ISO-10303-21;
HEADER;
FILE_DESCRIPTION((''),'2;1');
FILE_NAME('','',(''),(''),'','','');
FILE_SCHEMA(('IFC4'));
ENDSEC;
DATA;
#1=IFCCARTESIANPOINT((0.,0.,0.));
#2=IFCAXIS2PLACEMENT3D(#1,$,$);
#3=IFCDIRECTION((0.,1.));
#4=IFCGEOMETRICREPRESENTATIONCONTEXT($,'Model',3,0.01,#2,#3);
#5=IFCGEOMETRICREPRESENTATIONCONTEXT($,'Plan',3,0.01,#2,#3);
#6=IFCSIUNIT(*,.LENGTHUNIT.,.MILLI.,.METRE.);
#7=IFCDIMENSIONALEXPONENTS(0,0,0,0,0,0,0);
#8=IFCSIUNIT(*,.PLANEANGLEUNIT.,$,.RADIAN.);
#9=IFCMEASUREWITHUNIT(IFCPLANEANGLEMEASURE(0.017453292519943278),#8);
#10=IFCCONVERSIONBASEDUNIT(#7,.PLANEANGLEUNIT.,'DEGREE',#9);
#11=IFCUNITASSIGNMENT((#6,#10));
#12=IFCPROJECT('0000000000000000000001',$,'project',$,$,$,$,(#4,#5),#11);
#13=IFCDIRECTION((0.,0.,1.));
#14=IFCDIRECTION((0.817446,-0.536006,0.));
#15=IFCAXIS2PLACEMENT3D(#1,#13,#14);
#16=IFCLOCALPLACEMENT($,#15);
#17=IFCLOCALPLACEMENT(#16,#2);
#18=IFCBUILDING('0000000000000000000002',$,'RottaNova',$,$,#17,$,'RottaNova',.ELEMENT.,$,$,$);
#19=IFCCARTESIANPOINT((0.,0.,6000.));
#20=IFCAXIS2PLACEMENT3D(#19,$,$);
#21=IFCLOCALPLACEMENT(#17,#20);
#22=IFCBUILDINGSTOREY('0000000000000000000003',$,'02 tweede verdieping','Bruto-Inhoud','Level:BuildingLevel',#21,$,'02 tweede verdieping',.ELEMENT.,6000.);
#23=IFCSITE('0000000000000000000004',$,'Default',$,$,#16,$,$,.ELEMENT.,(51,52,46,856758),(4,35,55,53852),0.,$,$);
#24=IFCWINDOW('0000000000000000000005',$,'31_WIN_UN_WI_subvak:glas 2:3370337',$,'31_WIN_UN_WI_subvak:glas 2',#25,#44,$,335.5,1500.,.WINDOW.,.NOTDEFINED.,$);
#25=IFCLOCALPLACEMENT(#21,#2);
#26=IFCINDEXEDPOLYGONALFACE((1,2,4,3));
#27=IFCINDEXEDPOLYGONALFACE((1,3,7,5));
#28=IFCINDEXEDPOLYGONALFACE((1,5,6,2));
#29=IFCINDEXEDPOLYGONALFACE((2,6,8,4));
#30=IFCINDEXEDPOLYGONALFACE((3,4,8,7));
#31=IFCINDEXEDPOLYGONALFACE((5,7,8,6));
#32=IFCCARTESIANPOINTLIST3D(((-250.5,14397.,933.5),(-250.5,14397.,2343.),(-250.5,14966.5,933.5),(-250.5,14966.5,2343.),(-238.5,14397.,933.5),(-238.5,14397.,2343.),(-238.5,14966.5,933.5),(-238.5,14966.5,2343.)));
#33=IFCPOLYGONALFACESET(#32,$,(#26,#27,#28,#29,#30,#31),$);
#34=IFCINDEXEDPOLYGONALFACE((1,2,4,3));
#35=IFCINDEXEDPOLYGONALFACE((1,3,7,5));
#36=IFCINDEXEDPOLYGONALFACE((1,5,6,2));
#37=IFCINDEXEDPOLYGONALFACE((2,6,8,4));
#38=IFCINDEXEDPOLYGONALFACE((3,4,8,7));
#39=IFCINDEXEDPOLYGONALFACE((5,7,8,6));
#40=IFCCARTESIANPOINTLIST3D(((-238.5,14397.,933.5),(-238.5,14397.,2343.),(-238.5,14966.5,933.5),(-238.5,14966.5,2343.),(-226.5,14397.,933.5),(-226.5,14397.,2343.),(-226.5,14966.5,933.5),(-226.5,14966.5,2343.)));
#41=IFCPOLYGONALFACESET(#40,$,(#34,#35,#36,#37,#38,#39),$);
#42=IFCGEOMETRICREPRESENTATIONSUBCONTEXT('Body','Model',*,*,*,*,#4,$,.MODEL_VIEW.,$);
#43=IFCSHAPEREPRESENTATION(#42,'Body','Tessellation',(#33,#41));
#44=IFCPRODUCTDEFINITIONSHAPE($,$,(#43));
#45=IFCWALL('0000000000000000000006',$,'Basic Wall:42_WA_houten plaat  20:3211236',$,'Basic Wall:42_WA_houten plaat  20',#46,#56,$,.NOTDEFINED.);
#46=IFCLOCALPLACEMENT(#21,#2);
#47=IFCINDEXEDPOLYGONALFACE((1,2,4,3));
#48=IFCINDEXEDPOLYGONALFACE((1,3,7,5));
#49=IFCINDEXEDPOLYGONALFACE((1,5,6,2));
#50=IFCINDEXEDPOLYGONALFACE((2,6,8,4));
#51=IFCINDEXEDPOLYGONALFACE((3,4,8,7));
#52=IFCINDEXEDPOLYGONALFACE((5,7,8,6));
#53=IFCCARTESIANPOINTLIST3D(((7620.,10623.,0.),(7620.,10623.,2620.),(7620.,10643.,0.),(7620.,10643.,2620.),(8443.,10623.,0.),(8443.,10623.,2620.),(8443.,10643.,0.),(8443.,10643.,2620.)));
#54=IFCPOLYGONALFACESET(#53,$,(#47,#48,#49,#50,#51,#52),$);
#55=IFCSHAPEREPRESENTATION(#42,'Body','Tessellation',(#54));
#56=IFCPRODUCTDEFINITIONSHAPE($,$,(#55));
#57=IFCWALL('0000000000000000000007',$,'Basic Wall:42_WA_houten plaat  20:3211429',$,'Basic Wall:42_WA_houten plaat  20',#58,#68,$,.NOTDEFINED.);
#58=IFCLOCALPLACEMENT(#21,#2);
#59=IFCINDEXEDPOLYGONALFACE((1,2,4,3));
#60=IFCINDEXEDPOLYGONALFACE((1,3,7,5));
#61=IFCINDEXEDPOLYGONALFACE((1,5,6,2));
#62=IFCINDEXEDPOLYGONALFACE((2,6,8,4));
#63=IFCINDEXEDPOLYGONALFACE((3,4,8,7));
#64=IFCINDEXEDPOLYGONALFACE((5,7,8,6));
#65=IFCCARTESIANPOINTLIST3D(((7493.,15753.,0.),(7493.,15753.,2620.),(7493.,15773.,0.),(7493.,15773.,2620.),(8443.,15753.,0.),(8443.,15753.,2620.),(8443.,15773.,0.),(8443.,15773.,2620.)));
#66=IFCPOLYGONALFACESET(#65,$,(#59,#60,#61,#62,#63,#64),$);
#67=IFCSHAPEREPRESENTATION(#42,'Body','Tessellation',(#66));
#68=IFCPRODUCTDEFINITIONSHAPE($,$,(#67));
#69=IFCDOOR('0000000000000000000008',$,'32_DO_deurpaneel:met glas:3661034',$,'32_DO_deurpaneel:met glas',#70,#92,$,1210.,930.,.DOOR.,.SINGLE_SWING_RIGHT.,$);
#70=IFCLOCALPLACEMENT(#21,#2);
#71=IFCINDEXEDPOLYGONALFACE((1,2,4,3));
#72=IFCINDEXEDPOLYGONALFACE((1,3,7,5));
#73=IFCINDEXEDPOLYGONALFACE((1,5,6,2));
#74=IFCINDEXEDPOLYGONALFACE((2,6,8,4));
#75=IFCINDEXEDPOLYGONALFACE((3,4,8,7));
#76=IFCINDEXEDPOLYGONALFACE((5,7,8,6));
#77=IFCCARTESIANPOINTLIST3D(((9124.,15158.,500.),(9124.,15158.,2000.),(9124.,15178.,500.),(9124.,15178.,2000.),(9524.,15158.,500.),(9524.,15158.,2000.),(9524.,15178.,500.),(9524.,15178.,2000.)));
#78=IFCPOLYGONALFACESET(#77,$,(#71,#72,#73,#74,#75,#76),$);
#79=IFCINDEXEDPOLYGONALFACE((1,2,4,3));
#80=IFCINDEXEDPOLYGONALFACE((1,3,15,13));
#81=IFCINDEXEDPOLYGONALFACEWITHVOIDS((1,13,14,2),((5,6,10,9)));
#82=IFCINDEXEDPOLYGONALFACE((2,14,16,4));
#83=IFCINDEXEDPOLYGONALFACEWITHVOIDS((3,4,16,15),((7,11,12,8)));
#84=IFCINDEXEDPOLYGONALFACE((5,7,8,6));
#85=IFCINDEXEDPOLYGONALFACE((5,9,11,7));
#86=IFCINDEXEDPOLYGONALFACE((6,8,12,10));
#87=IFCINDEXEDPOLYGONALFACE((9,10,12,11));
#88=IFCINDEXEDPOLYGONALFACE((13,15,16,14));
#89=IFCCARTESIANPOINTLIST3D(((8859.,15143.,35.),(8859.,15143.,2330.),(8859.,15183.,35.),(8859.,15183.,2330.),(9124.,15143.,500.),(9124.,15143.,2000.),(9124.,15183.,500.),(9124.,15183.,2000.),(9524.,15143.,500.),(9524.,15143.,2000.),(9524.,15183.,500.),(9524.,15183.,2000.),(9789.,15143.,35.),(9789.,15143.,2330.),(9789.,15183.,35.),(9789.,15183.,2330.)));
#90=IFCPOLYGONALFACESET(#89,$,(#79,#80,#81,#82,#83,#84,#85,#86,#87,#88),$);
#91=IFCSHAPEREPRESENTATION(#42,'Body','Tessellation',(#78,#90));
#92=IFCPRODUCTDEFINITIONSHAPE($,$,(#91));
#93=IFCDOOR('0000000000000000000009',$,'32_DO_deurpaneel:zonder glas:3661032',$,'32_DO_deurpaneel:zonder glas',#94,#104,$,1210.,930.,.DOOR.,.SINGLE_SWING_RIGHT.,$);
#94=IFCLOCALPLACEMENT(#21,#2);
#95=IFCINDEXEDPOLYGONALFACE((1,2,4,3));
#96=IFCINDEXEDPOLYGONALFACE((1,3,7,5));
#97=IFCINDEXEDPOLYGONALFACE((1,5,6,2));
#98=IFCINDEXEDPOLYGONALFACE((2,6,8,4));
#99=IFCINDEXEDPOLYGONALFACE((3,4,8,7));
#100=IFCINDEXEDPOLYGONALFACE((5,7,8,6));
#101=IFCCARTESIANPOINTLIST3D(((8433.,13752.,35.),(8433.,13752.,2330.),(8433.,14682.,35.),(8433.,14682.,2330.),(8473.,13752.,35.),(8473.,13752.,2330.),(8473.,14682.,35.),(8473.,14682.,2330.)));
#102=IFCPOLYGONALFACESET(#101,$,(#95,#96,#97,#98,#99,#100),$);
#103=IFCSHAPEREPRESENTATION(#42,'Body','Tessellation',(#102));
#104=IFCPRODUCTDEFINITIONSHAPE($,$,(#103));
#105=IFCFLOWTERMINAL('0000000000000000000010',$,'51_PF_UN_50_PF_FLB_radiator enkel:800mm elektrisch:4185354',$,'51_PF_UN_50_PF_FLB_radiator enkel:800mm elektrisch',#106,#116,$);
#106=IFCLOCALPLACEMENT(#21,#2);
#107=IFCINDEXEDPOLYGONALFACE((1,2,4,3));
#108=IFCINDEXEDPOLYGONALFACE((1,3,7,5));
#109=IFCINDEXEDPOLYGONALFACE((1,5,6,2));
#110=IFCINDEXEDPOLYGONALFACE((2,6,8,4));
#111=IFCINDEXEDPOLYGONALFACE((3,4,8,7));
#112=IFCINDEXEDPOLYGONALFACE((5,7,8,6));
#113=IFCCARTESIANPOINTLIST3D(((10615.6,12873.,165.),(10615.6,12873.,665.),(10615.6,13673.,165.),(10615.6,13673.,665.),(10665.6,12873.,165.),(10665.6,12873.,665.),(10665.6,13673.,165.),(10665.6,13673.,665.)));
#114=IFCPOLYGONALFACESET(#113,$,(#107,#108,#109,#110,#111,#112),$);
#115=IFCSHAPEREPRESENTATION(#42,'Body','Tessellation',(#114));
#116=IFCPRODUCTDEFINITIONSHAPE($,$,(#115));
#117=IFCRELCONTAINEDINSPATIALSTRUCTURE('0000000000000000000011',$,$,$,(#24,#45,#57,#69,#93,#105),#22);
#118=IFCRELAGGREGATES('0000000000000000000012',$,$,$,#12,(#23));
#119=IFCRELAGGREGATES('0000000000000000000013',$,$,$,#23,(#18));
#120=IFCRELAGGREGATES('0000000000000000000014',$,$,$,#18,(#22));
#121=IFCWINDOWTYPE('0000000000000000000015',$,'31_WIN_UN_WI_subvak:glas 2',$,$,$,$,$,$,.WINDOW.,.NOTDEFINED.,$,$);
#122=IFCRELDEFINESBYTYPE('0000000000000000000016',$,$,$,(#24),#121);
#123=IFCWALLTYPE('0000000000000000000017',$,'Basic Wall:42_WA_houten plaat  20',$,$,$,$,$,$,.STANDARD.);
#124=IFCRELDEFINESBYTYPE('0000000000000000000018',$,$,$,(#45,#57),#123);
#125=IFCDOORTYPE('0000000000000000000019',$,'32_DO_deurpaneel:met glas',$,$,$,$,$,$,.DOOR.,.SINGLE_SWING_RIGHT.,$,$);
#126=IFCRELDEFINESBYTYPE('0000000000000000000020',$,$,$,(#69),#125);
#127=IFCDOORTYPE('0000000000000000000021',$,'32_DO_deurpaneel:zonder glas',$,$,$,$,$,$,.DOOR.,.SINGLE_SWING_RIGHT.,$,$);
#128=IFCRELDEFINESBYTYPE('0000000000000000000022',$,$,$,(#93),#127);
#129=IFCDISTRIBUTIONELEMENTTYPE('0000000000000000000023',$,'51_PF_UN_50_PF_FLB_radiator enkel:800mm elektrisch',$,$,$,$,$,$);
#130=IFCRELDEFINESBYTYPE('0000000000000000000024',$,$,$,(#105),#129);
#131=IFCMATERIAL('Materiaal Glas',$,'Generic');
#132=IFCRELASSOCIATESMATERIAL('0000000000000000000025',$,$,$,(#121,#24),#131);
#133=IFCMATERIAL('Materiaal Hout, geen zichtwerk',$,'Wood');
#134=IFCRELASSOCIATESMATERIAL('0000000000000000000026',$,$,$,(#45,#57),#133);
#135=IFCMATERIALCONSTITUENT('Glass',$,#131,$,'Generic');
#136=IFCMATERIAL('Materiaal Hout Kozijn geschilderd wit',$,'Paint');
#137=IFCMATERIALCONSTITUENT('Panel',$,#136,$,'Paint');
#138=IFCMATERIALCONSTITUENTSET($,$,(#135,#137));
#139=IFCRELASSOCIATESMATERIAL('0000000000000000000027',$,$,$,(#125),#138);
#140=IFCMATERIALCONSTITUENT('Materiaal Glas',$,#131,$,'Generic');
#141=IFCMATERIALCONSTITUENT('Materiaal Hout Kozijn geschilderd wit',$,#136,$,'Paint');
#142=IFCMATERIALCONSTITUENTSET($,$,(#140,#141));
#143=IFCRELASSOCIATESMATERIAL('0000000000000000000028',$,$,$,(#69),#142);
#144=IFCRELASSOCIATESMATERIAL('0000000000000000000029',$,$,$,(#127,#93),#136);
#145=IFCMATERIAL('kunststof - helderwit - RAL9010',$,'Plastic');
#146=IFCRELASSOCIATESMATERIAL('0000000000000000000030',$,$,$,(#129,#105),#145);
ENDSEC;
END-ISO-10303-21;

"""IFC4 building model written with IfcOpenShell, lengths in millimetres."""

from ifc_helpers import new_model, entity, si_unit, converted_unit, direction, frame, origin, place, context, subcontext, project, spatial, indexed_curve, outline, extrude, source, transform, mapped, material, constituent, constituent_set, type_object, type_shapes, element, save


model = new_model("IFC4")

# Units and contexts
model_context = context("Model", 3, precision=0.01, world=origin(), true_north=direction((0.0, 1.0)))
plan_context = context("Plan", 3, precision=0.01, world=origin(), true_north=direction((0.0, 1.0)))
body_context = subcontext(model_context, "Body", "Model", "MODEL_VIEW")
ifc_project = project(units=[si_unit("LENGTHUNIT", "METRE", prefix="MILLI"), converted_unit("PLANEANGLEUNIT", "DEGREE", entity("IfcPlaneAngleMeasure", 0.017453292519943278), si_unit("PLANEANGLEUNIT", "RADIAN"), dimensions=[0, 0, 0, 0, 0, 0, 0])], contexts=[model_context, plan_context])

# Site, building, storey
site_placement = place(None, frame((0.0, 0.0, 0.0), z_axis=(0.0, 0.0, 1.0), x_axis=(0.817446, -0.536006, 0.0)))
site = spatial("IfcSite", under=ifc_project, at=site_placement, Name="Default", CompositionType="ELEMENT", RefLatitude=(51, 52, 46, 856758), RefLongitude=(4, 35, 55, 53852), RefElevation=0.0)
building_placement = place(site_placement, origin())
building = spatial("IfcBuilding", under=site, at=building_placement, Name="RottaNova", LongName="RottaNova", CompositionType="ELEMENT")
storey_placement = place(building_placement, frame((0.0, 0.0, 6000.0)))
storey = spatial("IfcBuildingStorey", under=building, at=storey_placement, Name="02 tweede verdieping", Description="Bruto-Inhoud", ObjectType="Level:BuildingLevel", LongName="02 tweede verdieping", CompositionType="ELEMENT", Elevation=6000.0)

# Shared definitions
ifc_material_1 = material(Name="Materiaal Glas", Category="Generic")

# Window
window_type = type_object("IfcWindowType", Name="31_WIN_UN_WI_subvak:glas 2", PartitioningType="NOTDEFINED", PredefinedType="WINDOW", material=ifc_material_1)
shared_shape_1 = source(origin(), body_context, "Body", "SweptSolid", [
    extrude(outline(indexed_curve([(-284.7, -6.0), (284.7, -6.0), (284.7, 6.0), (-284.7, 6.0), (-284.7, -6.0)], self_intersect=False)), frame((0.0, -6.0, 0.0)), (0.0, 0.0, 1.0), 1409.5),
    extrude(outline(indexed_curve([(-284.8, -6.0), (284.8, -6.0), (284.8, 6.0), (-284.8, 6.0), (-284.8, -6.0)], self_intersect=False)), frame((0.0, 6.0, 0.0)), (0.0, 0.0, 1.0), 1409.5),
])
type_shapes(window_type, [shared_shape_1])
window_1_placement = place(storey_placement, frame((-238.5, 14681.8, 933.5), z_axis=(0.0, 0.0, 1.0), x_axis=(0.0, -1.0, 0.0)))
element("IfcWindow", 1, at=window_1_placement, inside=storey, type_object=window_type, material=ifc_material_1, Name="31_WIN_UN_WI_subvak:glas 2:3370337", ObjectType="31_WIN_UN_WI_subvak:glas 2", OverallHeight=335.5, OverallWidth=1500.0, PartitioningType="NOTDEFINED", PredefinedType="WINDOW", context=body_context, shape_type="MappedRepresentation", body=[
    mapped(shared_shape_1, transform((0.0, 0.0, 0.0), scale=1.0)),
])

# Walls
ifc_material_2 = material(Name="Materiaal Hout, geen zichtwerk", Category="Wood")
wall_type_1 = type_object("IfcWallType", Name="Basic Wall:42_WA_houten plaat  20", PredefinedType="STANDARD")
wall_1_placement = place(storey_placement, frame((7620.0, 10633.0, 0.0)))
element("IfcWall", 2, at=wall_1_placement, inside=storey, type_object=wall_type_1, material=ifc_material_2, Name="Basic Wall:42_WA_houten plaat  20:3211236", ObjectType="Basic Wall:42_WA_houten plaat  20", PredefinedType="NOTDEFINED", context=body_context, shape_type="SweptSolid", body=[
    extrude(outline(indexed_curve([(823.0, 10.0), (0.0, 10.0), (0.0, -10.0), (823.0, -10.0), (823.0, 10.0)], self_intersect=False)), origin(), (0.0, 0.0, 1.0), 2620.0),
])
wall_2_placement = place(storey_placement, frame((7493.0, 15763.0, 0.0)))
element("IfcWall", 3, at=wall_2_placement, inside=storey, type_object=wall_type_1, material=ifc_material_2, Name="Basic Wall:42_WA_houten plaat  20:3211429", ObjectType="Basic Wall:42_WA_houten plaat  20", PredefinedType="NOTDEFINED", context=body_context, shape_type="SweptSolid", body=[
    extrude(outline(indexed_curve([(950.0, 10.0), (0.0, 10.0), (0.0, -10.0), (950.0, -10.0), (950.0, 10.0)], self_intersect=False)), origin(), (0.0, 0.0, 1.0), 2620.0),
])

# Doors
ifc_constituent_1 = constituent(ifc_material_1, Name="Materiaal Glas", Category="Generic")
ifc_material_3 = material(Name="Materiaal Hout Kozijn geschilderd wit", Category="Paint")
ifc_constituent_2 = constituent(ifc_material_3, Name="Materiaal Hout Kozijn geschilderd wit", Category="Paint")
ifc_constituent_set_1 = constituent_set(constituents=[ifc_constituent_1, ifc_constituent_2])
ifc_constituent_3 = constituent(ifc_material_1, Name="Glass", Category="Generic")
ifc_constituent_4 = constituent(ifc_material_3, Name="Panel", Category="Paint")
ifc_constituent_set_2 = constituent_set(constituents=[ifc_constituent_3, ifc_constituent_4])
door_type_1 = type_object("IfcDoorType", Name="32_DO_deurpaneel:met glas", OperationType="SINGLE_SWING_RIGHT", PredefinedType="DOOR", material=ifc_constituent_set_2)
shared_shape_2 = source(origin(), body_context, "Body", "SweptSolid", [
    extrude(outline(indexed_curve([(-200.0, -10.0), (200.0, -10.0), (200.0, 10.0), (-200.0, 10.0), (-200.0, -10.0)], self_intersect=False)), frame((0.0, -25.0, 500.0), z_axis=(0.0, 0.0, 1.0), x_axis=(-1.0, 0.0, 0.0)), (0.0, 0.0, 1.0), 1500.0),
    extrude(outline(indexed_curve([(-465.0, -1147.5), (465.0, -1147.5), (465.0, 1147.5), (-465.0, 1147.5), (-465.0, -1147.5)], self_intersect=False), holes=[indexed_curve([(-200.0, 817.5), (200.0, 817.5), (200.0, -682.5), (-200.0, -682.5), (-200.0, 817.5)], self_intersect=False)]), frame((0.0, -40.0, 1182.5), z_axis=(0.0, 1.0, 0.0), x_axis=(-1.0, 0.0, 0.0)), (0.0, 0.0, 1.0), 40.0),
])
type_shapes(door_type_1, [shared_shape_2])
door_1_placement = place(storey_placement, frame((9324.0, 15143.0, 0.0), z_axis=(0.0, 0.0, 1.0), x_axis=(-1.0, 0.0, 0.0)))
element("IfcDoor", 4, at=door_1_placement, inside=storey, type_object=door_type_1, material=ifc_constituent_set_1, Name="32_DO_deurpaneel:met glas:3661034", ObjectType="32_DO_deurpaneel:met glas", OperationType="SINGLE_SWING_RIGHT", OverallHeight=1210.0, OverallWidth=930.0, PredefinedType="DOOR", context=body_context, shape_type="MappedRepresentation", body=[
    mapped(shared_shape_2, transform((0.0, 0.0, 0.0), scale=1.0)),
])
door_type_2 = type_object("IfcDoorType", Name="32_DO_deurpaneel:zonder glas", OperationType="SINGLE_SWING_RIGHT", PredefinedType="DOOR", material=ifc_material_3)
shared_shape_3 = source(origin(), body_context, "Body", "SweptSolid", [
    extrude(outline(indexed_curve([(-20.0, -1147.5), (20.0, -1147.5), (20.0, 1147.5), (-20.0, 1147.5), (-20.0, -1147.5)], self_intersect=False)), frame((-465.0, -20.0, 1182.5), z_axis=(1.0, 0.0, 0.0), x_axis=(0.0, 1.0, 0.0)), (0.0, 0.0, 1.0), 930.0),
])
type_shapes(door_type_2, [shared_shape_3])
door_2_placement = place(storey_placement, frame((8473.0, 14217.0, 0.0), z_axis=(0.0, 0.0, 1.0), x_axis=(0.0, -1.0, 0.0)))
element("IfcDoor", 5, at=door_2_placement, inside=storey, type_object=door_type_2, material=ifc_material_3, Name="32_DO_deurpaneel:zonder glas:3661032", ObjectType="32_DO_deurpaneel:zonder glas", OperationType="SINGLE_SWING_RIGHT", OverallHeight=1210.0, OverallWidth=930.0, PredefinedType="DOOR", context=body_context, shape_type="MappedRepresentation", body=[
    mapped(shared_shape_3, transform((0.0, 0.0, 0.0), scale=1.0)),
])

# Flow terminal
ifc_material_4 = material(Name="kunststof - helderwit - RAL9010", Category="Plastic")
distribution_element_type = type_object("IfcDistributionElementType", Name="51_PF_UN_50_PF_FLB_radiator enkel:800mm elektrisch", material=ifc_material_4)
shared_shape_4 = source(origin(), body_context, "Body", "SweptSolid", [
    extrude(outline(indexed_curve([(-400.0, -25.0), (400.0, -25.0), (400.0, 25.0), (-400.0, 25.0), (-400.0, -25.0)], self_intersect=False)), frame((0.0, 75.0, 150.0), z_axis=(0.0, 0.0, 1.0), x_axis=(-1.0, 0.0, 0.0)), (0.0, 0.0, 1.0), 500.0),
])
type_shapes(distribution_element_type, [shared_shape_4])
flow_terminal_placement = place(storey_placement, frame((10565.6, 13273.0, 15.0), z_axis=(0.0, 0.0, 1.0), x_axis=(0.0, -1.0, 0.0)))
element("IfcFlowTerminal", 6, at=flow_terminal_placement, inside=storey, type_object=distribution_element_type, material=ifc_material_4, Name="51_PF_UN_50_PF_FLB_radiator enkel:800mm elektrisch:4185354", ObjectType="51_PF_UN_50_PF_FLB_radiator enkel:800mm elektrisch", context=body_context, shape_type="MappedRepresentation", body=[
    mapped(shared_shape_4, transform((0.0, 0.0, 0.0), scale=1.0)),
])

save(model, "model.ifc")
